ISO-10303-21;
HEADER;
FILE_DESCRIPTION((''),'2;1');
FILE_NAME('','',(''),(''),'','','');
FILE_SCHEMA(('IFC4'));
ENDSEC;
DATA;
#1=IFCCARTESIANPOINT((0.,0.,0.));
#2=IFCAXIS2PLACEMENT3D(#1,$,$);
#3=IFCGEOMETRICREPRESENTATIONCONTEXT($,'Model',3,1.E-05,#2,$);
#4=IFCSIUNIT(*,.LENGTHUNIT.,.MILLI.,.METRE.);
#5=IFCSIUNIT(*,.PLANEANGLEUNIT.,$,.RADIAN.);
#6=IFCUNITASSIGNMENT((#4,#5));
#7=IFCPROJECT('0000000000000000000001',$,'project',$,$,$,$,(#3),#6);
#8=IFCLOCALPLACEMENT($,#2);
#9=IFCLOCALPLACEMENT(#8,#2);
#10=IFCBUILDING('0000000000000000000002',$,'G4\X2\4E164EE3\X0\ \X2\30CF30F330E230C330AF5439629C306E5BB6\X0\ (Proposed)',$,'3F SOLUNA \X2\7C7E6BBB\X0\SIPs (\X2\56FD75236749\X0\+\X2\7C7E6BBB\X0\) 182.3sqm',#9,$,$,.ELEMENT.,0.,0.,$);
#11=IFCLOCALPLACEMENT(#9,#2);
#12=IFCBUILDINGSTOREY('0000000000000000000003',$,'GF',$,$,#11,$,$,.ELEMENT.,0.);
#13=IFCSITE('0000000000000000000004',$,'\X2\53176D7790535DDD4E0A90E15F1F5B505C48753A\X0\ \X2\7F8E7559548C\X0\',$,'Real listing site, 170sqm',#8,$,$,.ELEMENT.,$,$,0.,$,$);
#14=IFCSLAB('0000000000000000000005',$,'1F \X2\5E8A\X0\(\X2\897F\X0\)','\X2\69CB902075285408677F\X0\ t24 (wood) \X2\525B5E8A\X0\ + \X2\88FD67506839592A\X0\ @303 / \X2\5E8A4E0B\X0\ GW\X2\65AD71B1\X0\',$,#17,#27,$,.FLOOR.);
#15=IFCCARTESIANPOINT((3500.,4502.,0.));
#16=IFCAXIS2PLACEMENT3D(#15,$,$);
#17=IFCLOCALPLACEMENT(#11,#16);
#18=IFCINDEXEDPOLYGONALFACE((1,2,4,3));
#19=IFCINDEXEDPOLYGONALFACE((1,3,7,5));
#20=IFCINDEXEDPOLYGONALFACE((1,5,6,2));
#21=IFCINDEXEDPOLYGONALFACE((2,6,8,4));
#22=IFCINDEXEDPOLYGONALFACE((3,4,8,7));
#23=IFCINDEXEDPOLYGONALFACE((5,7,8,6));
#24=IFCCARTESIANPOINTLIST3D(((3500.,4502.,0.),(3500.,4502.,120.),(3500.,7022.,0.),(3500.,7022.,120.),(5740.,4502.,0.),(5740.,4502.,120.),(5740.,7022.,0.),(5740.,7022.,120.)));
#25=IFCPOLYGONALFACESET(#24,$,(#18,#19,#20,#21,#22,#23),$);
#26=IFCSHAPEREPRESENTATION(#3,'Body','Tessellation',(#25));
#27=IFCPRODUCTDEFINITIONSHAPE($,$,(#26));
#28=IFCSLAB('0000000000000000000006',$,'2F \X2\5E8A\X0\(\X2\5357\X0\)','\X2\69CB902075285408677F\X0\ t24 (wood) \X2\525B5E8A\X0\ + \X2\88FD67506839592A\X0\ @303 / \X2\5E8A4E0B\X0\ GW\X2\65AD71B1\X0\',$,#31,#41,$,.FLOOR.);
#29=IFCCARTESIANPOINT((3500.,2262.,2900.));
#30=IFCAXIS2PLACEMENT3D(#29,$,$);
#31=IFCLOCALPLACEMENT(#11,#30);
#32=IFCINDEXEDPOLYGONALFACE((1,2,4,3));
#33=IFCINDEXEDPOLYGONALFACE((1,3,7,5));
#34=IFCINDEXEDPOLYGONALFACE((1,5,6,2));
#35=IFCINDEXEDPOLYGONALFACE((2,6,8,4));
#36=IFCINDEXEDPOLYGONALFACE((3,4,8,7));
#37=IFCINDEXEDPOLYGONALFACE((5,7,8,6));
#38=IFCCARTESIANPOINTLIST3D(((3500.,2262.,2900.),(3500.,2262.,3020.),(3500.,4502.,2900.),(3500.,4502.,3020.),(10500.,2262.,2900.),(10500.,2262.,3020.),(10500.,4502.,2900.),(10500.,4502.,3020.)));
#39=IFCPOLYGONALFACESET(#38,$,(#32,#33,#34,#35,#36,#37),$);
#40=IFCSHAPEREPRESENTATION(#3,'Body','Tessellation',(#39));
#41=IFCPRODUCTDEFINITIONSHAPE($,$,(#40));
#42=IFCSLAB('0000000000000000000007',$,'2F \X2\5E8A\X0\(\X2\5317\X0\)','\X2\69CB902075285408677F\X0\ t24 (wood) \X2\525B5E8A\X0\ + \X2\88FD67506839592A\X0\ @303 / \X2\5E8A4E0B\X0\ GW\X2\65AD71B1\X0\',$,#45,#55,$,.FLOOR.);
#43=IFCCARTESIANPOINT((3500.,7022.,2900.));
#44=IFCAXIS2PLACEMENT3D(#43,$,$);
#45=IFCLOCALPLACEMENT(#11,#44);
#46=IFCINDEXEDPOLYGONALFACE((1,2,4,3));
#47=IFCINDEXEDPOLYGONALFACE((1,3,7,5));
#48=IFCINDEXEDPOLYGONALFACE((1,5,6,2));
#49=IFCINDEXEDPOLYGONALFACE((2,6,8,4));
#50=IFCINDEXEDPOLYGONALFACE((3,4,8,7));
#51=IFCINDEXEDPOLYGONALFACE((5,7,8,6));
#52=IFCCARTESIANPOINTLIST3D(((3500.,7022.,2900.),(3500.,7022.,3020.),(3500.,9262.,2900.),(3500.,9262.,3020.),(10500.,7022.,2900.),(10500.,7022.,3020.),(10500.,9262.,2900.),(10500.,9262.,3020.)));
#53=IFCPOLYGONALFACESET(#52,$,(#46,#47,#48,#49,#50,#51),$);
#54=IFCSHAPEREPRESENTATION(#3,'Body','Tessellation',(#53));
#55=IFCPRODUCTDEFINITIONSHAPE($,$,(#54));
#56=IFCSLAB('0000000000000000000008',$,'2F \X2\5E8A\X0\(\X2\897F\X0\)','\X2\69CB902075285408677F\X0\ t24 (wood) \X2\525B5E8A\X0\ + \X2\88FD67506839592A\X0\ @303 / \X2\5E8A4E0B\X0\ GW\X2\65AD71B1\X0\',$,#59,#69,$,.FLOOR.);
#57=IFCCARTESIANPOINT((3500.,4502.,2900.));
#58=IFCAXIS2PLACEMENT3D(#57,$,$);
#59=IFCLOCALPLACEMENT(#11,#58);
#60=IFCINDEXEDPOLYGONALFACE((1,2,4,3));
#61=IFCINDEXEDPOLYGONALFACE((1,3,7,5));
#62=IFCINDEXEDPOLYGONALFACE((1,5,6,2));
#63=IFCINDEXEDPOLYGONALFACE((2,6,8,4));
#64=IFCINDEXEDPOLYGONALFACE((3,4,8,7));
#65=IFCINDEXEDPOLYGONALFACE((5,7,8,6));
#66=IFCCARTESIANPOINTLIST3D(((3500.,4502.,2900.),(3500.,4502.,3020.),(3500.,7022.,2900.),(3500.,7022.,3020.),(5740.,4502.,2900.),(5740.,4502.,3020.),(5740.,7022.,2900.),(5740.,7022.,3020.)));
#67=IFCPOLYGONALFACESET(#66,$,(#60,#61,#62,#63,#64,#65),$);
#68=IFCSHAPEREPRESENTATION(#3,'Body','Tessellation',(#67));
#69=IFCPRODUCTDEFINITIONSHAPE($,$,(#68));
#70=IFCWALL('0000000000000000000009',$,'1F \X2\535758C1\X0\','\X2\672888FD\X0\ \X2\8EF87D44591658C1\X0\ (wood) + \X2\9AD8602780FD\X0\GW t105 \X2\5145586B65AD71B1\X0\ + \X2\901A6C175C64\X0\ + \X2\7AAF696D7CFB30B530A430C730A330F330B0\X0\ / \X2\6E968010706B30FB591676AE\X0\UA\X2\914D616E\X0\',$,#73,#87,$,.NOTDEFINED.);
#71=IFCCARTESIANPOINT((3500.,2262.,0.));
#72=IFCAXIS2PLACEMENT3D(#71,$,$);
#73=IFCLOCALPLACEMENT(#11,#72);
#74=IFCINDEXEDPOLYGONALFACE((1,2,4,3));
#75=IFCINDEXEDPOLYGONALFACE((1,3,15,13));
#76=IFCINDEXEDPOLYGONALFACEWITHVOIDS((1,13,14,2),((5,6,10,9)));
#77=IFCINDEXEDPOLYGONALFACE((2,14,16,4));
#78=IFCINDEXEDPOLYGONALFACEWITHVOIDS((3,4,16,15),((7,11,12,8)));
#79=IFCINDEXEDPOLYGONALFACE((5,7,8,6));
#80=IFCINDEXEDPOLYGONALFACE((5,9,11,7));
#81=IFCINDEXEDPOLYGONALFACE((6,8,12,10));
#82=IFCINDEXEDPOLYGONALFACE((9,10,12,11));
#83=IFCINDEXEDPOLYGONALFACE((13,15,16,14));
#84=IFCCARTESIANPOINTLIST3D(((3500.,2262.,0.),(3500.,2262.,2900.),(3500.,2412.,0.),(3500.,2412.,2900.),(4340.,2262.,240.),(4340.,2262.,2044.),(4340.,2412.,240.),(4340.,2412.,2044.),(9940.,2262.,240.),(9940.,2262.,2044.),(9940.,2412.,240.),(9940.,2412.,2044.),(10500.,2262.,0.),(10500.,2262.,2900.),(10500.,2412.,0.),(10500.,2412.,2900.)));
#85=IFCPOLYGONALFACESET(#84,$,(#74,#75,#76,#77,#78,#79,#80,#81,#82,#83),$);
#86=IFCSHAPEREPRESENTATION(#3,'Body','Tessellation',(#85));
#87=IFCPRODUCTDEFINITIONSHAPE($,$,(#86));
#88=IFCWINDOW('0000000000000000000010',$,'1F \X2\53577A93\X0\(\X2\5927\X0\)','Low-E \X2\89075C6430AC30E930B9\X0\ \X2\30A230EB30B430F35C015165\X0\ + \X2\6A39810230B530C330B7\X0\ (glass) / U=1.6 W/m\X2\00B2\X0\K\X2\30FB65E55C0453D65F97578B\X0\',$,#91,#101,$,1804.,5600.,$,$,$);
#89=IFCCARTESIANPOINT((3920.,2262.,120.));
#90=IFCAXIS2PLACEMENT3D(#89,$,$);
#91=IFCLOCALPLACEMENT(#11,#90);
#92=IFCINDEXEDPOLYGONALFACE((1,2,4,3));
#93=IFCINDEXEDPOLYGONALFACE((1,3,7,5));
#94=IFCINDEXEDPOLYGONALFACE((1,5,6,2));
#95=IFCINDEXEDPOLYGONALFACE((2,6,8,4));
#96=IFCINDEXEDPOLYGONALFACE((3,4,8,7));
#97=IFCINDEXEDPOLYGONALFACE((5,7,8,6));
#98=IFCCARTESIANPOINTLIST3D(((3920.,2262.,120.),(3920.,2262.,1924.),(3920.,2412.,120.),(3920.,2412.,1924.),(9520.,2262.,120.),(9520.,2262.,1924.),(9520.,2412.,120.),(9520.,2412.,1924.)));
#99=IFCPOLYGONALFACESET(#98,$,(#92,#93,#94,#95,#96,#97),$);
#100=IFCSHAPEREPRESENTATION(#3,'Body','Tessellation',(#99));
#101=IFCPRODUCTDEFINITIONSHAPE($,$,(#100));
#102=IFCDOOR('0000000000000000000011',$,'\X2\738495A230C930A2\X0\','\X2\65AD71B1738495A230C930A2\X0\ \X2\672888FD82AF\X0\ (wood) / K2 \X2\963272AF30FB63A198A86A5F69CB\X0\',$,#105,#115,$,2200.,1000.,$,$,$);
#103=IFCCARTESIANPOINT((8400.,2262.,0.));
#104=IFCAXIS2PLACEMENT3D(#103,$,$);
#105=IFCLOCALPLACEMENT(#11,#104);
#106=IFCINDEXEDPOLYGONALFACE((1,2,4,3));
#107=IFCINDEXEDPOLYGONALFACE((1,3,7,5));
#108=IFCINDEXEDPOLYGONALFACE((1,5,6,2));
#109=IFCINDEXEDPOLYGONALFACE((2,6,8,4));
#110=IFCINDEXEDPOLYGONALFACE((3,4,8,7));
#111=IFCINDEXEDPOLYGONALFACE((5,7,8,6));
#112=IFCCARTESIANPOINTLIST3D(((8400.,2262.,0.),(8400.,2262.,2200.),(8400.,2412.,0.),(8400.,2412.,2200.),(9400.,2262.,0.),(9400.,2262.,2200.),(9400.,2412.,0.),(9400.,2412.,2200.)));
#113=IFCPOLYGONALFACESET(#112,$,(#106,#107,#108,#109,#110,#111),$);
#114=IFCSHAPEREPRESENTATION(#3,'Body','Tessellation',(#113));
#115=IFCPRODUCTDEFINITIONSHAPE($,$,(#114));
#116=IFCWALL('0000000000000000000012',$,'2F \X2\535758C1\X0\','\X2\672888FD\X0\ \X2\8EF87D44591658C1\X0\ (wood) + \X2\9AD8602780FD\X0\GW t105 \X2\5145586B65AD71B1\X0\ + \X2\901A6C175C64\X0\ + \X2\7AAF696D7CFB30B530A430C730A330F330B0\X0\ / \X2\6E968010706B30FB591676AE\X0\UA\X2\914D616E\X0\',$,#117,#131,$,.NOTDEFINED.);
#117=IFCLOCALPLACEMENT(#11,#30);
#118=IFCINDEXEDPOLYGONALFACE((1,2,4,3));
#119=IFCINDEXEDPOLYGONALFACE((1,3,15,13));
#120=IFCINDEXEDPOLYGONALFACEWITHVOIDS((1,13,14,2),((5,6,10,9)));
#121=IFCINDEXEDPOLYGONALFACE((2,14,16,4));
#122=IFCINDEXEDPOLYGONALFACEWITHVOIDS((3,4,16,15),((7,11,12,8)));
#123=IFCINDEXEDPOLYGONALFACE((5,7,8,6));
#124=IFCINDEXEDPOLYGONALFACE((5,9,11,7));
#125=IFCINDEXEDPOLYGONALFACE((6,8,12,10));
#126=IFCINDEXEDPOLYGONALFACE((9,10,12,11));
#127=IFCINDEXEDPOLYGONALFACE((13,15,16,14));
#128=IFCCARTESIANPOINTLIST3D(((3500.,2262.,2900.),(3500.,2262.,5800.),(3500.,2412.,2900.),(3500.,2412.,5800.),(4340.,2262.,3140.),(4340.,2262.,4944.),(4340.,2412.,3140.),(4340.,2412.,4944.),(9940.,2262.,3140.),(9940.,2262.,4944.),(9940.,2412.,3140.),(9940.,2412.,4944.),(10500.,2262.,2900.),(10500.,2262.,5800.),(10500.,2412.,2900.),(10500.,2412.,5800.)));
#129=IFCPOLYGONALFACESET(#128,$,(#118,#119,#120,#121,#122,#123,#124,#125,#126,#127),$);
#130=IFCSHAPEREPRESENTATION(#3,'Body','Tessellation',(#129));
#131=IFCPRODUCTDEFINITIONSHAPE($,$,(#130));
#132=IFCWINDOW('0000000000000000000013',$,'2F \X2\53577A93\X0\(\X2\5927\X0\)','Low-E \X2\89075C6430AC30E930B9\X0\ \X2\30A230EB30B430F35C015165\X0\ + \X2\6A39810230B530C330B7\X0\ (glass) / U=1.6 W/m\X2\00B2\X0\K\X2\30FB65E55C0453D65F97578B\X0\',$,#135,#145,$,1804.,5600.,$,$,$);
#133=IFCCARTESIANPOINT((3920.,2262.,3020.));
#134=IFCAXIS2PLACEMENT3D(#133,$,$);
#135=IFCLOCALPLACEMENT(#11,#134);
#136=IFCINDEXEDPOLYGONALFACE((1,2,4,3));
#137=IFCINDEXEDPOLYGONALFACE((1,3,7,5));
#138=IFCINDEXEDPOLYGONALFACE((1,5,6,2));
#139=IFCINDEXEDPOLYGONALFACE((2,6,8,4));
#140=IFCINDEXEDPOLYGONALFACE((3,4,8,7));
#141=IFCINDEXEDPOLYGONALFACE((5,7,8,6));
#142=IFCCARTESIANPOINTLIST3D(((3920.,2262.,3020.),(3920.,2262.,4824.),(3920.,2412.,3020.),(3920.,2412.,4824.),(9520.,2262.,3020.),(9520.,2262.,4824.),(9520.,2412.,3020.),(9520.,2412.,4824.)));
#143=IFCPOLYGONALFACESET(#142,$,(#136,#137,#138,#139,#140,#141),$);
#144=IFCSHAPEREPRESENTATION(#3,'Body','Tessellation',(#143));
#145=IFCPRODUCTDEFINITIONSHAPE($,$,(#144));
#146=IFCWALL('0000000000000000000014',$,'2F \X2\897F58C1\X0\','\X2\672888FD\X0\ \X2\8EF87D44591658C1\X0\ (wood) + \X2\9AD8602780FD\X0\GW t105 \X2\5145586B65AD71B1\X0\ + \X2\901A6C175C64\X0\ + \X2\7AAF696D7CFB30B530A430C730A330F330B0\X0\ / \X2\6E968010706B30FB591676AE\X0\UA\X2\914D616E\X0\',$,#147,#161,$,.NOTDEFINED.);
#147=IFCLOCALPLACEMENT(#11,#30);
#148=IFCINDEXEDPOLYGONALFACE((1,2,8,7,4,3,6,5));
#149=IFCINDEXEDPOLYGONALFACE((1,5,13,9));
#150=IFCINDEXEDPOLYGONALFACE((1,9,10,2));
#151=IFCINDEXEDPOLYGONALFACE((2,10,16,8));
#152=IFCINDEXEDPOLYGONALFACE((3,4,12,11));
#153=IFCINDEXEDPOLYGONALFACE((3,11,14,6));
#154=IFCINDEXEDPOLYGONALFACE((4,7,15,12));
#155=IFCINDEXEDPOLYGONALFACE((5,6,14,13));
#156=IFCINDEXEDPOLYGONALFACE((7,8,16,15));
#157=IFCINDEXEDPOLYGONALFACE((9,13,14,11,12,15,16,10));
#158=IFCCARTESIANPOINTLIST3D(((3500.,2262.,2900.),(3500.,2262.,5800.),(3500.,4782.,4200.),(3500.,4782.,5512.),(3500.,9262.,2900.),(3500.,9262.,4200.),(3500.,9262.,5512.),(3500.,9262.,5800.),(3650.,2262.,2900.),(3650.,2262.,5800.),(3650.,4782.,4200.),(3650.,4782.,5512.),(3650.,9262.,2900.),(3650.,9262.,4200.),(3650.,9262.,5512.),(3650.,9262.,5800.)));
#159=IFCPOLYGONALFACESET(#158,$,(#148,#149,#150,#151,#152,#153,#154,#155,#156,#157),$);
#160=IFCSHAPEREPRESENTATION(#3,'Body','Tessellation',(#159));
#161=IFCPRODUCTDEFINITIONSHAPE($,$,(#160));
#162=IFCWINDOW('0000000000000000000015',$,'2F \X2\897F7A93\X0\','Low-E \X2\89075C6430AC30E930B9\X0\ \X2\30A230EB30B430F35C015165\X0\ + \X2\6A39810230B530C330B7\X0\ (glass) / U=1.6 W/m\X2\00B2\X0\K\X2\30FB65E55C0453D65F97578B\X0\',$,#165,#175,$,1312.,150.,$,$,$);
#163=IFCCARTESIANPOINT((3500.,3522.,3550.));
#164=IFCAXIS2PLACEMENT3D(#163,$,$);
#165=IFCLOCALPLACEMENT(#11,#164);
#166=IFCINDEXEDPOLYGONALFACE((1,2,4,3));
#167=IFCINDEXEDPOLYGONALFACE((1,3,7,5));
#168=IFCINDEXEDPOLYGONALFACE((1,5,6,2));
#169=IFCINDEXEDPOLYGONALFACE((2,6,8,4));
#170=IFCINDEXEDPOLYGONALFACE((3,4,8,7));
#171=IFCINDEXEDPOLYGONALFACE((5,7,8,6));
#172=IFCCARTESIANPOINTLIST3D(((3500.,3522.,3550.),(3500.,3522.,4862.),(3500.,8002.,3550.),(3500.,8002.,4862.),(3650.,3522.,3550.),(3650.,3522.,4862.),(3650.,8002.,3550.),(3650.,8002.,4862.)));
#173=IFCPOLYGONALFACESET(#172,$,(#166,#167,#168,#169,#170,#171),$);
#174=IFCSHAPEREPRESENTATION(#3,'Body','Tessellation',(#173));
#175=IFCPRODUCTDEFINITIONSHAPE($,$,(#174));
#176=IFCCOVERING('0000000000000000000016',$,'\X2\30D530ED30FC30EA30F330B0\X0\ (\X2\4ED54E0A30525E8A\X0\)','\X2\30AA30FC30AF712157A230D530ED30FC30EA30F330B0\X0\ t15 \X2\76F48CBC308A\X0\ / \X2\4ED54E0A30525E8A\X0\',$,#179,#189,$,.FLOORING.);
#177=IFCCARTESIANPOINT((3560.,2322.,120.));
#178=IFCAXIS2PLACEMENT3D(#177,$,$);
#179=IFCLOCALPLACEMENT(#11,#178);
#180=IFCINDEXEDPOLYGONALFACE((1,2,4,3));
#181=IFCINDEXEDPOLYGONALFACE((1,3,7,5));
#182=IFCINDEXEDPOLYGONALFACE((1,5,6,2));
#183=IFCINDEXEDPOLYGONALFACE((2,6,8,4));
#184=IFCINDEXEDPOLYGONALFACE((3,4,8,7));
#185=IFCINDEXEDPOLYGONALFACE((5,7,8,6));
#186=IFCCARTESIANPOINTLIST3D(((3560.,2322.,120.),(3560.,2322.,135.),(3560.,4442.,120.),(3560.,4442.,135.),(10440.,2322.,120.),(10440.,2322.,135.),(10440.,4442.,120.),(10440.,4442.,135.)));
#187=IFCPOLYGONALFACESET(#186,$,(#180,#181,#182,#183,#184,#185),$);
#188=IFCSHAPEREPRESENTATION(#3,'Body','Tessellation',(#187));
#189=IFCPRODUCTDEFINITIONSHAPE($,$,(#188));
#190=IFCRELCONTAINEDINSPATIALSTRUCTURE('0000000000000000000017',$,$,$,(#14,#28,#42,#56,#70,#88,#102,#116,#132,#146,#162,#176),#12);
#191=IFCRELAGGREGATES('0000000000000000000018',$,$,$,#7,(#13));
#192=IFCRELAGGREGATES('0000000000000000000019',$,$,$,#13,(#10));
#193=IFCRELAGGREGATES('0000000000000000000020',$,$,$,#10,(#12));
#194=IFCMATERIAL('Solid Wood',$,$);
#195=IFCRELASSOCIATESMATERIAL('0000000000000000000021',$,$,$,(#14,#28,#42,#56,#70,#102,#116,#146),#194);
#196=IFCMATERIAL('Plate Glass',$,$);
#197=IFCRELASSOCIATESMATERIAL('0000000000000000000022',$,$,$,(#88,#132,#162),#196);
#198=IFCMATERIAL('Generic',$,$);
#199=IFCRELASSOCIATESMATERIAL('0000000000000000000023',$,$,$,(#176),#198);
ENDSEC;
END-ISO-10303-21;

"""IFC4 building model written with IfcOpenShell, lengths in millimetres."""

from ifc_helpers import new_model, si_unit, frame, frame_2d, origin, place, context, project, spatial, rectangle, extrude, material, element, fill, save


model = new_model("IFC4")

# Units and contexts
model_context = context("Model", 3, precision=1e-05, world=origin())
ifc_project = project(units=[si_unit("LENGTHUNIT", "METRE", prefix="MILLI"), si_unit("PLANEANGLEUNIT", "RADIAN")], contexts=[model_context])

# Site, building, storey
site_placement = place(None, origin())
site = spatial("IfcSite", under=ifc_project, at=site_placement, Name="北海道川上郡弟子屈町 美留和", ObjectType="Real listing site, 170sqm", CompositionType="ELEMENT", RefElevation=0.0)
building_placement = place(site_placement, origin())
building = spatial("IfcBuilding", under=site, at=building_placement, Name="G4世代 ハンモック吹抜の家 (Proposed)", ObjectType="3F SOLUNA 籾殻SIPs (国産杉+籾殻) 182.3sqm", CompositionType="ELEMENT", ElevationOfRefHeight=0.0, ElevationOfTerrain=0.0)
storey_placement = place(building_placement, origin())
storey = spatial("IfcBuildingStorey", under=building, at=storey_placement, Name="GF", CompositionType="ELEMENT", Elevation=0.0)

# Slabs
ifc_material_1 = material(Name="Solid Wood")
slab_1_placement = place(storey_placement, frame((3500.0, 4502.0, 0.0)))
element("IfcSlab", 1, at=slab_1_placement, inside=storey, material=ifc_material_1, Name="1F 床(西)", Description="構造用合板 t24 (wood) 剛床 + 製材根太 @303 / 床下 GW断熱", PredefinedType="FLOOR", context=model_context, shape_type="SweptSolid", body=[
    extrude(rectangle(XDim=2240.0, YDim=2520.0, at=frame_2d((1120.0, 1260.0))), frame((3500.0, 4502.0, 0.0)), (0.0, 0.0, 1.0), 120.0),
])
slab_2_placement = place(storey_placement, frame((3500.0, 2262.0, 2900.0)))
element("IfcSlab", 2, at=slab_2_placement, inside=storey, material=ifc_material_1, Name="2F 床(南)", Description="構造用合板 t24 (wood) 剛床 + 製材根太 @303 / 床下 GW断熱", PredefinedType="FLOOR", context=model_context, shape_type="SweptSolid", body=[
    extrude(rectangle(XDim=7000.0, YDim=2240.0, at=frame_2d((3500.0, 1120.0))), frame((3500.0, 2262.0, 2900.0)), (0.0, 0.0, 1.0), 120.0),
])
slab_3_placement = place(storey_placement, frame((3500.0, 7022.0, 2900.0)))
element("IfcSlab", 3, at=slab_3_placement, inside=storey, material=ifc_material_1, Name="2F 床(北)", Description="構造用合板 t24 (wood) 剛床 + 製材根太 @303 / 床下 GW断熱", PredefinedType="FLOOR", context=model_context, shape_type="SweptSolid", body=[
    extrude(rectangle(XDim=7000.0, YDim=2240.0, at=frame_2d((3500.0, 1120.0))), frame((3500.0, 7022.0, 2900.0)), (0.0, 0.0, 1.0), 120.0),
])
slab_4_placement = place(storey_placement, frame((3500.0, 4502.0, 2900.0)))
element("IfcSlab", 4, at=slab_4_placement, inside=storey, material=ifc_material_1, Name="2F 床(西)", Description="構造用合板 t24 (wood) 剛床 + 製材根太 @303 / 床下 GW断熱", PredefinedType="FLOOR", context=model_context, shape_type="SweptSolid", body=[
    extrude(rectangle(XDim=2240.0, YDim=2520.0, at=frame_2d((1120.0, 1260.0))), frame((3500.0, 4502.0, 2900.0)), (0.0, 0.0, 1.0), 120.0),
])

# Wall, openings, window, door
wall_1_placement = place(storey_placement, frame((3500.0, 2262.0, 0.0)))
wall_1 = element("IfcWall", 5, at=wall_1_placement, inside=storey, material=ifc_material_1, Name="1F 南壁", Description="木製 軸組外壁 (wood) + 高性能GW t105 充填断熱 + 通気層 + 窯業系サイディング / 準耐火・外皮UA配慮", PredefinedType="NOTDEFINED", context=model_context, shape_type="SweptSolid", body=[
    extrude(rectangle(XDim=7000.0, YDim=150.0, at=frame_2d((3500.0, 75.0))), frame((3500.0, 2262.0, 0.0)), (0.0, 0.0, 1.0), 2900.0),
])
opening_1_placement = place(storey_placement, frame((3920.0, 2262.0, 120.0)))
opening_1 = element("IfcOpeningElement", 6, at=opening_1_placement, cuts=wall_1, PredefinedType="NOTDEFINED", context=model_context, shape_type="SweptSolid", body=[
    extrude(rectangle(XDim=5600.0, YDim=150.0, at=frame_2d((2800.0, 75.0))), frame((3920.0, 2262.0, 120.0)), (0.0, 0.0, 1.0), 1804.0),
])
opening_2_placement = place(storey_placement, frame((8400.0, 2262.0, 0.0)))
opening_2 = element("IfcOpeningElement", 7, at=opening_2_placement, cuts=wall_1, PredefinedType="NOTDEFINED", context=model_context, shape_type="SweptSolid", body=[
    extrude(rectangle(XDim=1000.0, YDim=150.0, at=frame_2d((500.0, 75.0))), frame((8400.0, 2262.0, 0.0)), (0.0, 0.0, 1.0), 2200.0),
])
ifc_material_2 = material(Name="Plate Glass")
window_1_placement = place(storey_placement, frame((3920.0, 2262.0, 120.0)))
window_1 = element("IfcWindow", 8, at=window_1_placement, inside=storey, material=ifc_material_2, Name="1F 南窓(大)", Description="Low-E 複層ガラス アルゴン封入 + 樹脂サッシ (glass) / U=1.6 W/m²K・日射取得型", OverallHeight=1804.0, OverallWidth=5600.0, context=model_context, shape_type="SweptSolid", body=[
    extrude(rectangle(XDim=5600.0, YDim=150.0, at=frame_2d((2800.0, 75.0))), frame((3920.0, 2262.0, 120.0)), (0.0, 0.0, 1.0), 1804.0),
])
fill(opening_1, window_1)
door_placement = place(storey_placement, frame((8400.0, 2262.0, 0.0)))
door = element("IfcDoor", 9, at=door_placement, inside=storey, material=ifc_material_1, Name="玄関ドア", Description="断熱玄関ドア 木製芯 (wood) / K2 防犯・採風機構", OverallHeight=2200.0, OverallWidth=1000.0, context=model_context, shape_type="SweptSolid", body=[
    extrude(rectangle(XDim=1000.0, YDim=150.0, at=frame_2d((500.0, 75.0))), frame((8400.0, 2262.0, 0.0)), (0.0, 0.0, 1.0), 2200.0),
])
fill(opening_2, door)

# Wall, opening, window
wall_2_placement = place(storey_placement, frame((3500.0, 2262.0, 2900.0)))
wall_2 = element("IfcWall", 10, at=wall_2_placement, inside=storey, material=ifc_material_1, Name="2F 南壁", Description="木製 軸組外壁 (wood) + 高性能GW t105 充填断熱 + 通気層 + 窯業系サイディング / 準耐火・外皮UA配慮", PredefinedType="NOTDEFINED", context=model_context, shape_type="SweptSolid", body=[
    extrude(rectangle(XDim=7000.0, YDim=150.0, at=frame_2d((3500.0, 75.0))), frame((3500.0, 2262.0, 2900.0)), (0.0, 0.0, 1.0), 2900.0),
])
opening_3_placement = place(storey_placement, frame((3920.0, 2262.0, 3020.0)))
opening_3 = element("IfcOpeningElement", 11, at=opening_3_placement, cuts=wall_2, PredefinedType="NOTDEFINED", context=model_context, shape_type="SweptSolid", body=[
    extrude(rectangle(XDim=5600.0, YDim=150.0, at=frame_2d((2800.0, 75.0))), frame((3920.0, 2262.0, 3020.0)), (0.0, 0.0, 1.0), 1804.0),
])
window_2_placement = place(storey_placement, frame((3920.0, 2262.0, 3020.0)))
window_2 = element("IfcWindow", 12, at=window_2_placement, inside=storey, material=ifc_material_2, Name="2F 南窓(大)", Description="Low-E 複層ガラス アルゴン封入 + 樹脂サッシ (glass) / U=1.6 W/m²K・日射取得型", OverallHeight=1804.0, OverallWidth=5600.0, context=model_context, shape_type="SweptSolid", body=[
    extrude(rectangle(XDim=5600.0, YDim=150.0, at=frame_2d((2800.0, 75.0))), frame((3920.0, 2262.0, 3020.0)), (0.0, 0.0, 1.0), 1804.0),
])
fill(opening_3, window_2)

# Wall, opening, window
wall_3_placement = place(storey_placement, frame((3500.0, 2262.0, 2900.0)))
wall_3 = element("IfcWall", 13, at=wall_3_placement, inside=storey, material=ifc_material_1, Name="2F 西壁", Description="木製 軸組外壁 (wood) + 高性能GW t105 充填断熱 + 通気層 + 窯業系サイディング / 準耐火・外皮UA配慮", PredefinedType="NOTDEFINED", context=model_context, shape_type="SweptSolid", body=[
    extrude(rectangle(XDim=150.0, YDim=7000.0, at=frame_2d((75.0, 3500.0))), frame((3500.0, 2262.0, 2900.0)), (0.0, 0.0, 1.0), 2900.0),
])
opening_4_placement = place(storey_placement, frame((3500.0, 3522.0, 3550.0)))
opening_4 = element("IfcOpeningElement", 14, at=opening_4_placement, cuts=wall_3, PredefinedType="NOTDEFINED", context=model_context, shape_type="SweptSolid", body=[
    extrude(rectangle(XDim=150.0, YDim=4480.0, at=frame_2d((75.0, 2240.0))), frame((3500.0, 3522.0, 3550.0)), (0.0, 0.0, 1.0), 1312.0),
])
window_3_placement = place(storey_placement, frame((3500.0, 3522.0, 3550.0)))
window_3 = element("IfcWindow", 15, at=window_3_placement, inside=storey, material=ifc_material_2, Name="2F 西窓", Description="Low-E 複層ガラス アルゴン封入 + 樹脂サッシ (glass) / U=1.6 W/m²K・日射取得型", OverallHeight=1312.0, OverallWidth=150.0, context=model_context, shape_type="SweptSolid", body=[
    extrude(rectangle(XDim=150.0, YDim=4480.0, at=frame_2d((75.0, 2240.0))), frame((3500.0, 3522.0, 3550.0)), (0.0, 0.0, 1.0), 1312.0),
])
fill(opening_4, window_3)

# Covering
ifc_material_3 = material(Name="Generic")
covering_1_placement = place(storey_placement, frame((3560.0, 2322.0, 120.0)))
element("IfcCovering", 16, at=covering_1_placement, inside=storey, material=ifc_material_3, Name="フローリング (仕上げ床)", Description="オーク無垢フローリング t15 直貼り / 仕上げ床", PredefinedType="FLOORING", context=model_context, shape_type="SweptSolid", body=[
    extrude(rectangle(XDim=6880.0, YDim=2120.0, at=frame_2d((3440.0, 1060.0))), frame((3560.0, 2322.0, 120.0)), (0.0, 0.0, 1.0), 15.0),
])

save(model, "model.ifc")
